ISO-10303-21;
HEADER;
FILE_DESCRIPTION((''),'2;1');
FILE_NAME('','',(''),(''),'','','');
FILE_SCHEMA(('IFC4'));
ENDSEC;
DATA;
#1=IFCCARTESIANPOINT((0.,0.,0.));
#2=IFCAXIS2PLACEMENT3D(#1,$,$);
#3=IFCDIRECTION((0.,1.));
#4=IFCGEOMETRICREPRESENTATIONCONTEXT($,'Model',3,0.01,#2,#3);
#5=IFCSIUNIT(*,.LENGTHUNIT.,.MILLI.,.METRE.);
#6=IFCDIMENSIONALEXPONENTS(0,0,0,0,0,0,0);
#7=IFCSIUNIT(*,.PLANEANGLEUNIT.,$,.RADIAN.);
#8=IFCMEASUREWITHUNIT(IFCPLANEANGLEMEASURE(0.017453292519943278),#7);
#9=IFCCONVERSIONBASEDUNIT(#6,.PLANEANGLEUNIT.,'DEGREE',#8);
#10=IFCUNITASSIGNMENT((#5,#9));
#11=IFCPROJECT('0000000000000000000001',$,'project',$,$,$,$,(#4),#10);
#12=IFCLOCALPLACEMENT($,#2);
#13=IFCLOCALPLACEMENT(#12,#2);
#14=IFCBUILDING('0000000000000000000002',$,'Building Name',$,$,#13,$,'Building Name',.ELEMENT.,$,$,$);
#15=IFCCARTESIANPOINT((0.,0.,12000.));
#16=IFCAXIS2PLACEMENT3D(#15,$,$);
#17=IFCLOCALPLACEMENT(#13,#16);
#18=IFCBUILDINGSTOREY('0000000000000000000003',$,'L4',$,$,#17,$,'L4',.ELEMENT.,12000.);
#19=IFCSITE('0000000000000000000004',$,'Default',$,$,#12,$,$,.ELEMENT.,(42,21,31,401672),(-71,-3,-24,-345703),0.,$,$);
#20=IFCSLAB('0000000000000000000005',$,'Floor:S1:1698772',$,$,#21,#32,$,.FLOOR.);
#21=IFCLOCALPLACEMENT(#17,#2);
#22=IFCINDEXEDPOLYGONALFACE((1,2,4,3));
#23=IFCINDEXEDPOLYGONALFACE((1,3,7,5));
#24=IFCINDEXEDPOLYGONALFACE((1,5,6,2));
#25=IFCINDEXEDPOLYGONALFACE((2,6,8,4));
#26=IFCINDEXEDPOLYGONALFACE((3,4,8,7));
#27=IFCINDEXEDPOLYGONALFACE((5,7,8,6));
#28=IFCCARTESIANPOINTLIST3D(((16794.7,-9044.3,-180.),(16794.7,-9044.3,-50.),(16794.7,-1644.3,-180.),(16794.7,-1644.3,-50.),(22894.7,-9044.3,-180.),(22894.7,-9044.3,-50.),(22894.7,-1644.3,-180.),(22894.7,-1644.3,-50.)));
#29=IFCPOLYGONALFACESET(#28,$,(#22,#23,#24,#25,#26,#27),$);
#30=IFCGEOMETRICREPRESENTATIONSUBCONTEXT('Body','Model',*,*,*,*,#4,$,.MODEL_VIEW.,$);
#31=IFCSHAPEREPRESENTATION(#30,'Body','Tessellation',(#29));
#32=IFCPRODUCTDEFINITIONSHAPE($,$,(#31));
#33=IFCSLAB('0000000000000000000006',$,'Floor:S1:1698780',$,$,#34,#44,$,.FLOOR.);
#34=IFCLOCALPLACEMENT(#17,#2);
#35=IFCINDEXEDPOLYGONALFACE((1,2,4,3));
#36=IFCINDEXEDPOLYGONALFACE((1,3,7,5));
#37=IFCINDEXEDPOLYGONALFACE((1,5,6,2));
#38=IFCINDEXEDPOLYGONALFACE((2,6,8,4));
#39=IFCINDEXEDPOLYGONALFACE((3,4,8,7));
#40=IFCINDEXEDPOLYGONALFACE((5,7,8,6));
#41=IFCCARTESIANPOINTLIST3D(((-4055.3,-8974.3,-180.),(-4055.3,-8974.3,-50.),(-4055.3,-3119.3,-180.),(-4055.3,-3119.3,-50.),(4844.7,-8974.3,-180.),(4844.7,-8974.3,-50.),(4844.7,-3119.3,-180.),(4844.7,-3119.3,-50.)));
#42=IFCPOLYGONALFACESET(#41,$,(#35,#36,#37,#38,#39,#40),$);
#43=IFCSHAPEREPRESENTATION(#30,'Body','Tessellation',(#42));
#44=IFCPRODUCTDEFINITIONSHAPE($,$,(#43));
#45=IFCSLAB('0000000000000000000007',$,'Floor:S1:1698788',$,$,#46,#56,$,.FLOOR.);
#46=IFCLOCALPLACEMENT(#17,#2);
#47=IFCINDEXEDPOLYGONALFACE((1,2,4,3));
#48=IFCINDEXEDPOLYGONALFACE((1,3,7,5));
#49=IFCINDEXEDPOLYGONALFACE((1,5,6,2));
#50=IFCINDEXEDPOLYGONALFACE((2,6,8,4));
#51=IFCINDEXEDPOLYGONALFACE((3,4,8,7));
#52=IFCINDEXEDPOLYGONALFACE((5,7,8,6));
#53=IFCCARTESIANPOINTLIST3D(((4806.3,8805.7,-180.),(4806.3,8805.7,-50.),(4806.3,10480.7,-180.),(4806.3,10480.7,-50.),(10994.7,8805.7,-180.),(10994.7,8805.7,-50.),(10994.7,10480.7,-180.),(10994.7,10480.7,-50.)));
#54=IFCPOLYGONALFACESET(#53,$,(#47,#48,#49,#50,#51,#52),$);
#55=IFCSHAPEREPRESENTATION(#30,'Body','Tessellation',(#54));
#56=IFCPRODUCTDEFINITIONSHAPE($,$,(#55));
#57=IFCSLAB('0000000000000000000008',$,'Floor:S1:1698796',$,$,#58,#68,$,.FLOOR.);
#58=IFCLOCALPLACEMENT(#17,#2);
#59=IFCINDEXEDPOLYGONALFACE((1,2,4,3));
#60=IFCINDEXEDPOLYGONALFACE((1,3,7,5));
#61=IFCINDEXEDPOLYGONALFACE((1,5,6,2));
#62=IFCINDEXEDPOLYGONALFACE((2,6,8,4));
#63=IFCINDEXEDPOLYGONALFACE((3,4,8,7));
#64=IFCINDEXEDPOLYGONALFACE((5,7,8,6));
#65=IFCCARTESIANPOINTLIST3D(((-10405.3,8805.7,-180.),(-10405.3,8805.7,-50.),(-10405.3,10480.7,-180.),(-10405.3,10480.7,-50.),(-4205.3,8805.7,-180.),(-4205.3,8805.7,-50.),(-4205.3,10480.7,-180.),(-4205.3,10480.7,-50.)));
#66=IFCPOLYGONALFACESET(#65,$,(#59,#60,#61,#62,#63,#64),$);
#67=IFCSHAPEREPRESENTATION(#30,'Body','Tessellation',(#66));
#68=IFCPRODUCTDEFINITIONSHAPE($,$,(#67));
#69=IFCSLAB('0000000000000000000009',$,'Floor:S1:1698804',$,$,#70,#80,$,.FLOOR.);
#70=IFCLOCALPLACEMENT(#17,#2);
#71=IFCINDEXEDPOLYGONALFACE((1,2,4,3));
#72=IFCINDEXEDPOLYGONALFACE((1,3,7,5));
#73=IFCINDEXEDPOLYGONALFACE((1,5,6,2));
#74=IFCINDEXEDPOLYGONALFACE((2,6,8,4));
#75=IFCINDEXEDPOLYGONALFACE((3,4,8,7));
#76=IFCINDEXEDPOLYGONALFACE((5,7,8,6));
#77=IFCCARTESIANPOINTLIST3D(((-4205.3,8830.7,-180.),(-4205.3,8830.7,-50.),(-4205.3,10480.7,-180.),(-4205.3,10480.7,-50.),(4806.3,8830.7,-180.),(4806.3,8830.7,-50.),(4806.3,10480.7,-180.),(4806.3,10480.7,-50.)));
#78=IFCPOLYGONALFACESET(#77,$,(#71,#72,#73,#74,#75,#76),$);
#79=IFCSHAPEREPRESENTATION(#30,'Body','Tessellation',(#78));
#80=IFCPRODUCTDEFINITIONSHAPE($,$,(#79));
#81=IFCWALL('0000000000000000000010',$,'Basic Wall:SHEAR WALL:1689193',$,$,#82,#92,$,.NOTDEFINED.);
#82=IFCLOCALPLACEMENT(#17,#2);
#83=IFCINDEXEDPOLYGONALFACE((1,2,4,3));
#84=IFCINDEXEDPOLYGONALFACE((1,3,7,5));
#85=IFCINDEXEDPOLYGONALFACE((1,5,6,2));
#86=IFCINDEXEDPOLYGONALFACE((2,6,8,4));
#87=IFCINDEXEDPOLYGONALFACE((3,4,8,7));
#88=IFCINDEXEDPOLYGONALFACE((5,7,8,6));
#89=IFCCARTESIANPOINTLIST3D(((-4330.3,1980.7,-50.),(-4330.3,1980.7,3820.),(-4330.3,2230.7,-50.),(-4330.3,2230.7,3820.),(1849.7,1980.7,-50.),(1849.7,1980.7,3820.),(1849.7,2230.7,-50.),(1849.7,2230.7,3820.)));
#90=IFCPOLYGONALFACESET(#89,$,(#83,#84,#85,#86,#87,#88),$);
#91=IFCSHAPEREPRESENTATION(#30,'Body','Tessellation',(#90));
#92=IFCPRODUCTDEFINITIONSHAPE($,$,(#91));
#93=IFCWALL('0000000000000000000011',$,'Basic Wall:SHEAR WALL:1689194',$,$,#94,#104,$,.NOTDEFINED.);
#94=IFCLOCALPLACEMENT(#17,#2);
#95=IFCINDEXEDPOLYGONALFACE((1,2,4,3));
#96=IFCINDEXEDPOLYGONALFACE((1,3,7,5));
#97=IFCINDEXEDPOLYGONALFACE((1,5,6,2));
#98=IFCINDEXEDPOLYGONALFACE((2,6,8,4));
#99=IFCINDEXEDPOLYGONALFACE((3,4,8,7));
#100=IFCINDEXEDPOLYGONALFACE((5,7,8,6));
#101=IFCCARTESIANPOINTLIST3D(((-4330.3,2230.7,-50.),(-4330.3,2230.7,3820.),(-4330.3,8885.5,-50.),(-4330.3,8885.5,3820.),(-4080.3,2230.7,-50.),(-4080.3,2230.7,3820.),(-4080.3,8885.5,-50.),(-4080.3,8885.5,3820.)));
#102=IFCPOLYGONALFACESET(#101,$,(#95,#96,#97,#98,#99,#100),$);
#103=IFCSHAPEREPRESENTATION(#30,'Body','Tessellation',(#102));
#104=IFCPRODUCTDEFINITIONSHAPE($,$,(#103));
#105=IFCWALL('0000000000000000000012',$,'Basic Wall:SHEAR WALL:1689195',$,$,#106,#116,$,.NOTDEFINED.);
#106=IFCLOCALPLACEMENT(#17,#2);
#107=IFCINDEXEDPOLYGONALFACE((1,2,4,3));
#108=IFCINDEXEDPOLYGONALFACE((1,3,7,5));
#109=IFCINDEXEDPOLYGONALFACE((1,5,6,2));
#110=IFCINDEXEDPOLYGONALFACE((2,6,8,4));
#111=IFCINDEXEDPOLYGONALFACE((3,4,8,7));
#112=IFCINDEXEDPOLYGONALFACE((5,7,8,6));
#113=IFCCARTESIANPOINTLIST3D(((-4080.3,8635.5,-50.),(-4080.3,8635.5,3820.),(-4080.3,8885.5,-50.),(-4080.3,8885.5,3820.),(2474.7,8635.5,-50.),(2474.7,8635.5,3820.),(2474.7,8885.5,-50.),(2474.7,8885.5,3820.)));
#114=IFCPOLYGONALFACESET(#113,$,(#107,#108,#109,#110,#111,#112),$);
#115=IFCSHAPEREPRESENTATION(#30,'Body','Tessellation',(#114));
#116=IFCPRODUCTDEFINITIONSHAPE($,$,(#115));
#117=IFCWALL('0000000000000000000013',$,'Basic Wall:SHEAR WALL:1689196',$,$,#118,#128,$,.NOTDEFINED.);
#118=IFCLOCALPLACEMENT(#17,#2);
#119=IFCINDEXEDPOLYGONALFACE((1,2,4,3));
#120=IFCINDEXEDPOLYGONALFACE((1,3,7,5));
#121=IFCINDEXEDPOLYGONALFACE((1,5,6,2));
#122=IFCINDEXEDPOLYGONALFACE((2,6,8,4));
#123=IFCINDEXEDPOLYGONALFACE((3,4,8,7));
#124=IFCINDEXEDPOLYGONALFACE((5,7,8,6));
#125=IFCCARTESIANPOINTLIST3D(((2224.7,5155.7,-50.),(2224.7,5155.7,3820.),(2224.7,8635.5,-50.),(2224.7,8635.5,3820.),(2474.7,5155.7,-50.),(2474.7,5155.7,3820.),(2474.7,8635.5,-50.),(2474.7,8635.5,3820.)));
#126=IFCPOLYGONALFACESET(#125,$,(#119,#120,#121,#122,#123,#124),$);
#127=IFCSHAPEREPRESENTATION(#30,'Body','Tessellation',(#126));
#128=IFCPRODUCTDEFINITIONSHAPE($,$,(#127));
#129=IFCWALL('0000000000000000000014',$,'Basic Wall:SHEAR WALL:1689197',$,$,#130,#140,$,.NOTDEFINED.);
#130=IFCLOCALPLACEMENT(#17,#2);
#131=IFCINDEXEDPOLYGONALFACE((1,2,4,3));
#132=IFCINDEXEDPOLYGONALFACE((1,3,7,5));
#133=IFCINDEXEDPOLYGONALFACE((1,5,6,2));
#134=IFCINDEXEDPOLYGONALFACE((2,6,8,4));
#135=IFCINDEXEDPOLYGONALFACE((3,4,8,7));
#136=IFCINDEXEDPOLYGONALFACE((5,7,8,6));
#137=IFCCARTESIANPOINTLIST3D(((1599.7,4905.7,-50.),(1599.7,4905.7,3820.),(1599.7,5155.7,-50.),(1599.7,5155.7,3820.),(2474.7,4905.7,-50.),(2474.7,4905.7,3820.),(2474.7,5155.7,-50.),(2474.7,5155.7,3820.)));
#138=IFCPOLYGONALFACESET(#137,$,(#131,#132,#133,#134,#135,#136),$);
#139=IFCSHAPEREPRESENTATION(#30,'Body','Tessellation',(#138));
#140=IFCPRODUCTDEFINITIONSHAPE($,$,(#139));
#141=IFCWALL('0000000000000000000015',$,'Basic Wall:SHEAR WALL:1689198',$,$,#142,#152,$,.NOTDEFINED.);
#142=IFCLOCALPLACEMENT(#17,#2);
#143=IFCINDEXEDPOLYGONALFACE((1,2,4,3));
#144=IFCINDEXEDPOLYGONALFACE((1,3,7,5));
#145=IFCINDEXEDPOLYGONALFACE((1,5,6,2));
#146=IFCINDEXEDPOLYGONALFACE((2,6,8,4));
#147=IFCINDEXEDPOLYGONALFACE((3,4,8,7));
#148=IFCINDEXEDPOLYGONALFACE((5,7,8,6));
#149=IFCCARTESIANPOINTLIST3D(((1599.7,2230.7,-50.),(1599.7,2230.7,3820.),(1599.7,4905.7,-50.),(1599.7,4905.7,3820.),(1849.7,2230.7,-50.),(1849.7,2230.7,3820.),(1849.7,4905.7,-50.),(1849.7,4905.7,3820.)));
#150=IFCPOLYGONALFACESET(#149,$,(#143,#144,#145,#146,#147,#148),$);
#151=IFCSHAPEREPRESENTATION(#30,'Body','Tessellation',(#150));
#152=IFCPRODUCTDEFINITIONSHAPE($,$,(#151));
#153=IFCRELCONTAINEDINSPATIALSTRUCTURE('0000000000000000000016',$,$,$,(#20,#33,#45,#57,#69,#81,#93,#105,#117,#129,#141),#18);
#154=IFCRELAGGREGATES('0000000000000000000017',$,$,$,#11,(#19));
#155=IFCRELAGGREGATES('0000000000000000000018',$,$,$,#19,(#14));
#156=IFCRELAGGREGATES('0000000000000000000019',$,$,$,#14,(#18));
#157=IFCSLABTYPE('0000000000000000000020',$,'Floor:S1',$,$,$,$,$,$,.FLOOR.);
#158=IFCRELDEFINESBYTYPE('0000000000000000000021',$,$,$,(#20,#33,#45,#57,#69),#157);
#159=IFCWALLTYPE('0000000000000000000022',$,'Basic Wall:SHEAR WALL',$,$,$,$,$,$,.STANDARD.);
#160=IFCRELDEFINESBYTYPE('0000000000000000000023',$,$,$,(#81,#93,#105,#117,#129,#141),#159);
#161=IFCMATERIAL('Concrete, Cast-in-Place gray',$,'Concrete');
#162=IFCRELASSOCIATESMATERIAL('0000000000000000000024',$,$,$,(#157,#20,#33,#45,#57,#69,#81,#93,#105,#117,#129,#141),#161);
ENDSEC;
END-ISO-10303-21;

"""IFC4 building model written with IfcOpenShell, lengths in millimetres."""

from ifc_helpers import new_model, entity, si_unit, converted_unit, direction, frame, origin, place, context, subcontext, project, spatial, indexed_curve, outline, extrude, material, type_object, element, save


model = new_model("IFC4")

# Units and contexts
model_context = context("Model", 3, precision=0.01, world=origin(), true_north=direction((0.0, 1.0)))
body_context = subcontext(model_context, "Body", "Model", "MODEL_VIEW")
ifc_project = project(units=[si_unit("LENGTHUNIT", "METRE", prefix="MILLI"), converted_unit("PLANEANGLEUNIT", "DEGREE", entity("IfcPlaneAngleMeasure", 0.017453292519943278), si_unit("PLANEANGLEUNIT", "RADIAN"), dimensions=[0, 0, 0, 0, 0, 0, 0])], contexts=[model_context])

# Site, building, storey
site_placement = place(None, origin())
site = spatial("IfcSite", under=ifc_project, at=site_placement, Name="Default", CompositionType="ELEMENT", RefLatitude=(42, 21, 31, 401672), RefLongitude=(-71, -3, -24, -345703), RefElevation=0.0)
building_placement = place(site_placement, origin())
building = spatial("IfcBuilding", under=site, at=building_placement, Name="Building Name", LongName="Building Name", CompositionType="ELEMENT")
storey_placement = place(building_placement, frame((0.0, 0.0, 12000.0)))
storey = spatial("IfcBuildingStorey", under=building, at=storey_placement, Name="L4", LongName="L4", CompositionType="ELEMENT", Elevation=12000.0)

# Shared definitions
ifc_material = material(Name="Concrete, Cast-in-Place gray", Category="Concrete")

# Slabs
slab_type = type_object("IfcSlabType", Name="Floor:S1", PredefinedType="FLOOR", material=ifc_material)
slab_1_placement = place(storey_placement, origin())
element("IfcSlab", 1, at=slab_1_placement, inside=storey, type_object=slab_type, material=ifc_material, Name="Floor:S1:1698772", PredefinedType="FLOOR", context=body_context, shape_type="SweptSolid", body=[
    extrude(outline(indexed_curve([(-3700.0, -3050.0), (3700.0, -3050.0), (3700.0, 3050.0), (-3700.0, 3050.0), (-3700.0, -3050.0)], self_intersect=False)), frame((19844.7, -5344.3, -50.0), z_axis=(0.0, 0.0, -1.0), x_axis=(0.0, 1.0, 0.0)), (0.0, 0.0, 1.0), 130.0),
])
slab_2_placement = place(storey_placement, origin())
element("IfcSlab", 2, at=slab_2_placement, inside=storey, type_object=slab_type, material=ifc_material, Name="Floor:S1:1698780", PredefinedType="FLOOR", context=body_context, shape_type="SweptSolid", body=[
    extrude(outline(indexed_curve([(-2927.5, -4450.0), (2927.5, -4450.0), (2927.5, 4450.0), (-2927.5, 4450.0), (-2927.5, -4450.0)], self_intersect=False)), frame((394.7, -6046.8, -50.0), z_axis=(0.0, 0.0, -1.0), x_axis=(0.0, 1.0, 0.0)), (0.0, 0.0, 1.0), 130.0),
])
slab_3_placement = place(storey_placement, origin())
element("IfcSlab", 3, at=slab_3_placement, inside=storey, type_object=slab_type, material=ifc_material, Name="Floor:S1:1698788", PredefinedType="FLOOR", context=body_context, shape_type="SweptSolid", body=[
    extrude(outline(indexed_curve([(-837.5, -3094.2), (837.5, -3094.2), (837.5, 3094.2), (-837.5, 3094.2), (-837.5, -3094.2)], self_intersect=False)), frame((7900.5, 9643.2, -50.0), z_axis=(0.0, 0.0, -1.0), x_axis=(0.0, 1.0, 0.0)), (0.0, 0.0, 1.0), 130.0),
])
slab_4_placement = place(storey_placement, origin())
element("IfcSlab", 4, at=slab_4_placement, inside=storey, type_object=slab_type, material=ifc_material, Name="Floor:S1:1698796", PredefinedType="FLOOR", context=body_context, shape_type="SweptSolid", body=[
    extrude(outline(indexed_curve([(-837.5, -3100.0), (837.5, -3100.0), (837.5, 3100.0), (-837.5, 3100.0), (-837.5, -3100.0)], self_intersect=False)), frame((-7305.3, 9643.2, -50.0), z_axis=(0.0, 0.0, -1.0), x_axis=(0.0, 1.0, 0.0)), (0.0, 0.0, 1.0), 130.0),
])
slab_5_placement = place(storey_placement, origin())
element("IfcSlab", 5, at=slab_5_placement, inside=storey, type_object=slab_type, material=ifc_material, Name="Floor:S1:1698804", PredefinedType="FLOOR", context=body_context, shape_type="SweptSolid", body=[
    extrude(outline(indexed_curve([(-825.0, -4505.8), (825.0, -4505.8), (825.0, 4505.8), (-825.0, 4505.8), (-825.0, -4505.8)], self_intersect=False)), frame((300.5, 9655.7, -50.0), z_axis=(0.0, 0.0, -1.0), x_axis=(0.0, 1.0, 0.0)), (0.0, 0.0, 1.0), 130.0),
])

# Walls
wall_type = type_object("IfcWallType", Name="Basic Wall:SHEAR WALL", PredefinedType="STANDARD")
wall_1_placement = place(storey_placement, frame((-4330.3, 2105.7, -50.0)))
element("IfcWall", 6, at=wall_1_placement, inside=storey, type_object=wall_type, material=ifc_material, Name="Basic Wall:SHEAR WALL:1689193", PredefinedType="NOTDEFINED", context=body_context, shape_type="SweptSolid", body=[
    extrude(outline(indexed_curve([(6180.0, 125.0), (0.0, 125.0), (0.0, -125.0), (6180.0, -125.0), (6180.0, 125.0)], self_intersect=False)), origin(), (0.0, 0.0, 1.0), 3870.0),
])
wall_2_placement = place(storey_placement, frame((-4205.3, 2230.7, -50.0), z_axis=(0.0, 0.0, 1.0), x_axis=(0.0, 1.0, 0.0)))
element("IfcWall", 7, at=wall_2_placement, inside=storey, type_object=wall_type, material=ifc_material, Name="Basic Wall:SHEAR WALL:1689194", PredefinedType="NOTDEFINED", context=body_context, shape_type="SweptSolid", body=[
    extrude(outline(indexed_curve([(6654.9, 125.0), (0.0, 125.0), (0.0, -125.0), (6654.9, -125.0), (6654.9, 125.0)], self_intersect=False)), origin(), (0.0, 0.0, 1.0), 3870.0),
])
wall_3_placement = place(storey_placement, frame((-4080.3, 8760.5, -50.0)))
element("IfcWall", 8, at=wall_3_placement, inside=storey, type_object=wall_type, material=ifc_material, Name="Basic Wall:SHEAR WALL:1689195", PredefinedType="NOTDEFINED", context=body_context, shape_type="SweptSolid", body=[
    extrude(outline(indexed_curve([(6555.0, 125.0), (0.0, 125.0), (0.0, -125.0), (6555.0, -125.0), (6555.0, 125.0)], self_intersect=False)), origin(), (0.0, 0.0, 1.0), 3870.0),
])
wall_4_placement = place(storey_placement, frame((2349.7, 8635.5, -50.0), z_axis=(0.0, 0.0, 1.0), x_axis=(0.0, -1.0, 0.0)))
element("IfcWall", 9, at=wall_4_placement, inside=storey, type_object=wall_type, material=ifc_material, Name="Basic Wall:SHEAR WALL:1689196", PredefinedType="NOTDEFINED", context=body_context, shape_type="SweptSolid", body=[
    extrude(outline(indexed_curve([(3479.9, 125.0), (0.0, 125.0), (0.0, -125.0), (3479.9, -125.0), (3479.9, 125.0)], self_intersect=False)), origin(), (0.0, 0.0, 1.0), 3870.0),
])
wall_5_placement = place(storey_placement, frame((2474.7, 5030.7, -50.0), z_axis=(0.0, 0.0, 1.0), x_axis=(-1.0, 0.0, 0.0)))
element("IfcWall", 10, at=wall_5_placement, inside=storey, type_object=wall_type, material=ifc_material, Name="Basic Wall:SHEAR WALL:1689197", PredefinedType="NOTDEFINED", context=body_context, shape_type="SweptSolid", body=[
    extrude(outline(indexed_curve([(875.0, 125.0), (0.0, 125.0), (0.0, -125.0), (875.0, -125.0), (875.0, 125.0)], self_intersect=False)), origin(), (0.0, 0.0, 1.0), 3870.0),
])
wall_6_placement = place(storey_placement, frame((1724.7, 4905.7, -50.0), z_axis=(0.0, 0.0, 1.0), x_axis=(0.0, -1.0, 0.0)))
element("IfcWall", 11, at=wall_6_placement, inside=storey, type_object=wall_type, material=ifc_material, Name="Basic Wall:SHEAR WALL:1689198", PredefinedType="NOTDEFINED", context=body_context, shape_type="SweptSolid", body=[
    extrude(outline(indexed_curve([(2675.0, 125.0), (0.0, 125.0), (0.0, -125.0), (2675.0, -125.0), (2675.0, 125.0)], self_intersect=False)), origin(), (0.0, 0.0, 1.0), 3870.0),
])

save(model, "model.ifc")
